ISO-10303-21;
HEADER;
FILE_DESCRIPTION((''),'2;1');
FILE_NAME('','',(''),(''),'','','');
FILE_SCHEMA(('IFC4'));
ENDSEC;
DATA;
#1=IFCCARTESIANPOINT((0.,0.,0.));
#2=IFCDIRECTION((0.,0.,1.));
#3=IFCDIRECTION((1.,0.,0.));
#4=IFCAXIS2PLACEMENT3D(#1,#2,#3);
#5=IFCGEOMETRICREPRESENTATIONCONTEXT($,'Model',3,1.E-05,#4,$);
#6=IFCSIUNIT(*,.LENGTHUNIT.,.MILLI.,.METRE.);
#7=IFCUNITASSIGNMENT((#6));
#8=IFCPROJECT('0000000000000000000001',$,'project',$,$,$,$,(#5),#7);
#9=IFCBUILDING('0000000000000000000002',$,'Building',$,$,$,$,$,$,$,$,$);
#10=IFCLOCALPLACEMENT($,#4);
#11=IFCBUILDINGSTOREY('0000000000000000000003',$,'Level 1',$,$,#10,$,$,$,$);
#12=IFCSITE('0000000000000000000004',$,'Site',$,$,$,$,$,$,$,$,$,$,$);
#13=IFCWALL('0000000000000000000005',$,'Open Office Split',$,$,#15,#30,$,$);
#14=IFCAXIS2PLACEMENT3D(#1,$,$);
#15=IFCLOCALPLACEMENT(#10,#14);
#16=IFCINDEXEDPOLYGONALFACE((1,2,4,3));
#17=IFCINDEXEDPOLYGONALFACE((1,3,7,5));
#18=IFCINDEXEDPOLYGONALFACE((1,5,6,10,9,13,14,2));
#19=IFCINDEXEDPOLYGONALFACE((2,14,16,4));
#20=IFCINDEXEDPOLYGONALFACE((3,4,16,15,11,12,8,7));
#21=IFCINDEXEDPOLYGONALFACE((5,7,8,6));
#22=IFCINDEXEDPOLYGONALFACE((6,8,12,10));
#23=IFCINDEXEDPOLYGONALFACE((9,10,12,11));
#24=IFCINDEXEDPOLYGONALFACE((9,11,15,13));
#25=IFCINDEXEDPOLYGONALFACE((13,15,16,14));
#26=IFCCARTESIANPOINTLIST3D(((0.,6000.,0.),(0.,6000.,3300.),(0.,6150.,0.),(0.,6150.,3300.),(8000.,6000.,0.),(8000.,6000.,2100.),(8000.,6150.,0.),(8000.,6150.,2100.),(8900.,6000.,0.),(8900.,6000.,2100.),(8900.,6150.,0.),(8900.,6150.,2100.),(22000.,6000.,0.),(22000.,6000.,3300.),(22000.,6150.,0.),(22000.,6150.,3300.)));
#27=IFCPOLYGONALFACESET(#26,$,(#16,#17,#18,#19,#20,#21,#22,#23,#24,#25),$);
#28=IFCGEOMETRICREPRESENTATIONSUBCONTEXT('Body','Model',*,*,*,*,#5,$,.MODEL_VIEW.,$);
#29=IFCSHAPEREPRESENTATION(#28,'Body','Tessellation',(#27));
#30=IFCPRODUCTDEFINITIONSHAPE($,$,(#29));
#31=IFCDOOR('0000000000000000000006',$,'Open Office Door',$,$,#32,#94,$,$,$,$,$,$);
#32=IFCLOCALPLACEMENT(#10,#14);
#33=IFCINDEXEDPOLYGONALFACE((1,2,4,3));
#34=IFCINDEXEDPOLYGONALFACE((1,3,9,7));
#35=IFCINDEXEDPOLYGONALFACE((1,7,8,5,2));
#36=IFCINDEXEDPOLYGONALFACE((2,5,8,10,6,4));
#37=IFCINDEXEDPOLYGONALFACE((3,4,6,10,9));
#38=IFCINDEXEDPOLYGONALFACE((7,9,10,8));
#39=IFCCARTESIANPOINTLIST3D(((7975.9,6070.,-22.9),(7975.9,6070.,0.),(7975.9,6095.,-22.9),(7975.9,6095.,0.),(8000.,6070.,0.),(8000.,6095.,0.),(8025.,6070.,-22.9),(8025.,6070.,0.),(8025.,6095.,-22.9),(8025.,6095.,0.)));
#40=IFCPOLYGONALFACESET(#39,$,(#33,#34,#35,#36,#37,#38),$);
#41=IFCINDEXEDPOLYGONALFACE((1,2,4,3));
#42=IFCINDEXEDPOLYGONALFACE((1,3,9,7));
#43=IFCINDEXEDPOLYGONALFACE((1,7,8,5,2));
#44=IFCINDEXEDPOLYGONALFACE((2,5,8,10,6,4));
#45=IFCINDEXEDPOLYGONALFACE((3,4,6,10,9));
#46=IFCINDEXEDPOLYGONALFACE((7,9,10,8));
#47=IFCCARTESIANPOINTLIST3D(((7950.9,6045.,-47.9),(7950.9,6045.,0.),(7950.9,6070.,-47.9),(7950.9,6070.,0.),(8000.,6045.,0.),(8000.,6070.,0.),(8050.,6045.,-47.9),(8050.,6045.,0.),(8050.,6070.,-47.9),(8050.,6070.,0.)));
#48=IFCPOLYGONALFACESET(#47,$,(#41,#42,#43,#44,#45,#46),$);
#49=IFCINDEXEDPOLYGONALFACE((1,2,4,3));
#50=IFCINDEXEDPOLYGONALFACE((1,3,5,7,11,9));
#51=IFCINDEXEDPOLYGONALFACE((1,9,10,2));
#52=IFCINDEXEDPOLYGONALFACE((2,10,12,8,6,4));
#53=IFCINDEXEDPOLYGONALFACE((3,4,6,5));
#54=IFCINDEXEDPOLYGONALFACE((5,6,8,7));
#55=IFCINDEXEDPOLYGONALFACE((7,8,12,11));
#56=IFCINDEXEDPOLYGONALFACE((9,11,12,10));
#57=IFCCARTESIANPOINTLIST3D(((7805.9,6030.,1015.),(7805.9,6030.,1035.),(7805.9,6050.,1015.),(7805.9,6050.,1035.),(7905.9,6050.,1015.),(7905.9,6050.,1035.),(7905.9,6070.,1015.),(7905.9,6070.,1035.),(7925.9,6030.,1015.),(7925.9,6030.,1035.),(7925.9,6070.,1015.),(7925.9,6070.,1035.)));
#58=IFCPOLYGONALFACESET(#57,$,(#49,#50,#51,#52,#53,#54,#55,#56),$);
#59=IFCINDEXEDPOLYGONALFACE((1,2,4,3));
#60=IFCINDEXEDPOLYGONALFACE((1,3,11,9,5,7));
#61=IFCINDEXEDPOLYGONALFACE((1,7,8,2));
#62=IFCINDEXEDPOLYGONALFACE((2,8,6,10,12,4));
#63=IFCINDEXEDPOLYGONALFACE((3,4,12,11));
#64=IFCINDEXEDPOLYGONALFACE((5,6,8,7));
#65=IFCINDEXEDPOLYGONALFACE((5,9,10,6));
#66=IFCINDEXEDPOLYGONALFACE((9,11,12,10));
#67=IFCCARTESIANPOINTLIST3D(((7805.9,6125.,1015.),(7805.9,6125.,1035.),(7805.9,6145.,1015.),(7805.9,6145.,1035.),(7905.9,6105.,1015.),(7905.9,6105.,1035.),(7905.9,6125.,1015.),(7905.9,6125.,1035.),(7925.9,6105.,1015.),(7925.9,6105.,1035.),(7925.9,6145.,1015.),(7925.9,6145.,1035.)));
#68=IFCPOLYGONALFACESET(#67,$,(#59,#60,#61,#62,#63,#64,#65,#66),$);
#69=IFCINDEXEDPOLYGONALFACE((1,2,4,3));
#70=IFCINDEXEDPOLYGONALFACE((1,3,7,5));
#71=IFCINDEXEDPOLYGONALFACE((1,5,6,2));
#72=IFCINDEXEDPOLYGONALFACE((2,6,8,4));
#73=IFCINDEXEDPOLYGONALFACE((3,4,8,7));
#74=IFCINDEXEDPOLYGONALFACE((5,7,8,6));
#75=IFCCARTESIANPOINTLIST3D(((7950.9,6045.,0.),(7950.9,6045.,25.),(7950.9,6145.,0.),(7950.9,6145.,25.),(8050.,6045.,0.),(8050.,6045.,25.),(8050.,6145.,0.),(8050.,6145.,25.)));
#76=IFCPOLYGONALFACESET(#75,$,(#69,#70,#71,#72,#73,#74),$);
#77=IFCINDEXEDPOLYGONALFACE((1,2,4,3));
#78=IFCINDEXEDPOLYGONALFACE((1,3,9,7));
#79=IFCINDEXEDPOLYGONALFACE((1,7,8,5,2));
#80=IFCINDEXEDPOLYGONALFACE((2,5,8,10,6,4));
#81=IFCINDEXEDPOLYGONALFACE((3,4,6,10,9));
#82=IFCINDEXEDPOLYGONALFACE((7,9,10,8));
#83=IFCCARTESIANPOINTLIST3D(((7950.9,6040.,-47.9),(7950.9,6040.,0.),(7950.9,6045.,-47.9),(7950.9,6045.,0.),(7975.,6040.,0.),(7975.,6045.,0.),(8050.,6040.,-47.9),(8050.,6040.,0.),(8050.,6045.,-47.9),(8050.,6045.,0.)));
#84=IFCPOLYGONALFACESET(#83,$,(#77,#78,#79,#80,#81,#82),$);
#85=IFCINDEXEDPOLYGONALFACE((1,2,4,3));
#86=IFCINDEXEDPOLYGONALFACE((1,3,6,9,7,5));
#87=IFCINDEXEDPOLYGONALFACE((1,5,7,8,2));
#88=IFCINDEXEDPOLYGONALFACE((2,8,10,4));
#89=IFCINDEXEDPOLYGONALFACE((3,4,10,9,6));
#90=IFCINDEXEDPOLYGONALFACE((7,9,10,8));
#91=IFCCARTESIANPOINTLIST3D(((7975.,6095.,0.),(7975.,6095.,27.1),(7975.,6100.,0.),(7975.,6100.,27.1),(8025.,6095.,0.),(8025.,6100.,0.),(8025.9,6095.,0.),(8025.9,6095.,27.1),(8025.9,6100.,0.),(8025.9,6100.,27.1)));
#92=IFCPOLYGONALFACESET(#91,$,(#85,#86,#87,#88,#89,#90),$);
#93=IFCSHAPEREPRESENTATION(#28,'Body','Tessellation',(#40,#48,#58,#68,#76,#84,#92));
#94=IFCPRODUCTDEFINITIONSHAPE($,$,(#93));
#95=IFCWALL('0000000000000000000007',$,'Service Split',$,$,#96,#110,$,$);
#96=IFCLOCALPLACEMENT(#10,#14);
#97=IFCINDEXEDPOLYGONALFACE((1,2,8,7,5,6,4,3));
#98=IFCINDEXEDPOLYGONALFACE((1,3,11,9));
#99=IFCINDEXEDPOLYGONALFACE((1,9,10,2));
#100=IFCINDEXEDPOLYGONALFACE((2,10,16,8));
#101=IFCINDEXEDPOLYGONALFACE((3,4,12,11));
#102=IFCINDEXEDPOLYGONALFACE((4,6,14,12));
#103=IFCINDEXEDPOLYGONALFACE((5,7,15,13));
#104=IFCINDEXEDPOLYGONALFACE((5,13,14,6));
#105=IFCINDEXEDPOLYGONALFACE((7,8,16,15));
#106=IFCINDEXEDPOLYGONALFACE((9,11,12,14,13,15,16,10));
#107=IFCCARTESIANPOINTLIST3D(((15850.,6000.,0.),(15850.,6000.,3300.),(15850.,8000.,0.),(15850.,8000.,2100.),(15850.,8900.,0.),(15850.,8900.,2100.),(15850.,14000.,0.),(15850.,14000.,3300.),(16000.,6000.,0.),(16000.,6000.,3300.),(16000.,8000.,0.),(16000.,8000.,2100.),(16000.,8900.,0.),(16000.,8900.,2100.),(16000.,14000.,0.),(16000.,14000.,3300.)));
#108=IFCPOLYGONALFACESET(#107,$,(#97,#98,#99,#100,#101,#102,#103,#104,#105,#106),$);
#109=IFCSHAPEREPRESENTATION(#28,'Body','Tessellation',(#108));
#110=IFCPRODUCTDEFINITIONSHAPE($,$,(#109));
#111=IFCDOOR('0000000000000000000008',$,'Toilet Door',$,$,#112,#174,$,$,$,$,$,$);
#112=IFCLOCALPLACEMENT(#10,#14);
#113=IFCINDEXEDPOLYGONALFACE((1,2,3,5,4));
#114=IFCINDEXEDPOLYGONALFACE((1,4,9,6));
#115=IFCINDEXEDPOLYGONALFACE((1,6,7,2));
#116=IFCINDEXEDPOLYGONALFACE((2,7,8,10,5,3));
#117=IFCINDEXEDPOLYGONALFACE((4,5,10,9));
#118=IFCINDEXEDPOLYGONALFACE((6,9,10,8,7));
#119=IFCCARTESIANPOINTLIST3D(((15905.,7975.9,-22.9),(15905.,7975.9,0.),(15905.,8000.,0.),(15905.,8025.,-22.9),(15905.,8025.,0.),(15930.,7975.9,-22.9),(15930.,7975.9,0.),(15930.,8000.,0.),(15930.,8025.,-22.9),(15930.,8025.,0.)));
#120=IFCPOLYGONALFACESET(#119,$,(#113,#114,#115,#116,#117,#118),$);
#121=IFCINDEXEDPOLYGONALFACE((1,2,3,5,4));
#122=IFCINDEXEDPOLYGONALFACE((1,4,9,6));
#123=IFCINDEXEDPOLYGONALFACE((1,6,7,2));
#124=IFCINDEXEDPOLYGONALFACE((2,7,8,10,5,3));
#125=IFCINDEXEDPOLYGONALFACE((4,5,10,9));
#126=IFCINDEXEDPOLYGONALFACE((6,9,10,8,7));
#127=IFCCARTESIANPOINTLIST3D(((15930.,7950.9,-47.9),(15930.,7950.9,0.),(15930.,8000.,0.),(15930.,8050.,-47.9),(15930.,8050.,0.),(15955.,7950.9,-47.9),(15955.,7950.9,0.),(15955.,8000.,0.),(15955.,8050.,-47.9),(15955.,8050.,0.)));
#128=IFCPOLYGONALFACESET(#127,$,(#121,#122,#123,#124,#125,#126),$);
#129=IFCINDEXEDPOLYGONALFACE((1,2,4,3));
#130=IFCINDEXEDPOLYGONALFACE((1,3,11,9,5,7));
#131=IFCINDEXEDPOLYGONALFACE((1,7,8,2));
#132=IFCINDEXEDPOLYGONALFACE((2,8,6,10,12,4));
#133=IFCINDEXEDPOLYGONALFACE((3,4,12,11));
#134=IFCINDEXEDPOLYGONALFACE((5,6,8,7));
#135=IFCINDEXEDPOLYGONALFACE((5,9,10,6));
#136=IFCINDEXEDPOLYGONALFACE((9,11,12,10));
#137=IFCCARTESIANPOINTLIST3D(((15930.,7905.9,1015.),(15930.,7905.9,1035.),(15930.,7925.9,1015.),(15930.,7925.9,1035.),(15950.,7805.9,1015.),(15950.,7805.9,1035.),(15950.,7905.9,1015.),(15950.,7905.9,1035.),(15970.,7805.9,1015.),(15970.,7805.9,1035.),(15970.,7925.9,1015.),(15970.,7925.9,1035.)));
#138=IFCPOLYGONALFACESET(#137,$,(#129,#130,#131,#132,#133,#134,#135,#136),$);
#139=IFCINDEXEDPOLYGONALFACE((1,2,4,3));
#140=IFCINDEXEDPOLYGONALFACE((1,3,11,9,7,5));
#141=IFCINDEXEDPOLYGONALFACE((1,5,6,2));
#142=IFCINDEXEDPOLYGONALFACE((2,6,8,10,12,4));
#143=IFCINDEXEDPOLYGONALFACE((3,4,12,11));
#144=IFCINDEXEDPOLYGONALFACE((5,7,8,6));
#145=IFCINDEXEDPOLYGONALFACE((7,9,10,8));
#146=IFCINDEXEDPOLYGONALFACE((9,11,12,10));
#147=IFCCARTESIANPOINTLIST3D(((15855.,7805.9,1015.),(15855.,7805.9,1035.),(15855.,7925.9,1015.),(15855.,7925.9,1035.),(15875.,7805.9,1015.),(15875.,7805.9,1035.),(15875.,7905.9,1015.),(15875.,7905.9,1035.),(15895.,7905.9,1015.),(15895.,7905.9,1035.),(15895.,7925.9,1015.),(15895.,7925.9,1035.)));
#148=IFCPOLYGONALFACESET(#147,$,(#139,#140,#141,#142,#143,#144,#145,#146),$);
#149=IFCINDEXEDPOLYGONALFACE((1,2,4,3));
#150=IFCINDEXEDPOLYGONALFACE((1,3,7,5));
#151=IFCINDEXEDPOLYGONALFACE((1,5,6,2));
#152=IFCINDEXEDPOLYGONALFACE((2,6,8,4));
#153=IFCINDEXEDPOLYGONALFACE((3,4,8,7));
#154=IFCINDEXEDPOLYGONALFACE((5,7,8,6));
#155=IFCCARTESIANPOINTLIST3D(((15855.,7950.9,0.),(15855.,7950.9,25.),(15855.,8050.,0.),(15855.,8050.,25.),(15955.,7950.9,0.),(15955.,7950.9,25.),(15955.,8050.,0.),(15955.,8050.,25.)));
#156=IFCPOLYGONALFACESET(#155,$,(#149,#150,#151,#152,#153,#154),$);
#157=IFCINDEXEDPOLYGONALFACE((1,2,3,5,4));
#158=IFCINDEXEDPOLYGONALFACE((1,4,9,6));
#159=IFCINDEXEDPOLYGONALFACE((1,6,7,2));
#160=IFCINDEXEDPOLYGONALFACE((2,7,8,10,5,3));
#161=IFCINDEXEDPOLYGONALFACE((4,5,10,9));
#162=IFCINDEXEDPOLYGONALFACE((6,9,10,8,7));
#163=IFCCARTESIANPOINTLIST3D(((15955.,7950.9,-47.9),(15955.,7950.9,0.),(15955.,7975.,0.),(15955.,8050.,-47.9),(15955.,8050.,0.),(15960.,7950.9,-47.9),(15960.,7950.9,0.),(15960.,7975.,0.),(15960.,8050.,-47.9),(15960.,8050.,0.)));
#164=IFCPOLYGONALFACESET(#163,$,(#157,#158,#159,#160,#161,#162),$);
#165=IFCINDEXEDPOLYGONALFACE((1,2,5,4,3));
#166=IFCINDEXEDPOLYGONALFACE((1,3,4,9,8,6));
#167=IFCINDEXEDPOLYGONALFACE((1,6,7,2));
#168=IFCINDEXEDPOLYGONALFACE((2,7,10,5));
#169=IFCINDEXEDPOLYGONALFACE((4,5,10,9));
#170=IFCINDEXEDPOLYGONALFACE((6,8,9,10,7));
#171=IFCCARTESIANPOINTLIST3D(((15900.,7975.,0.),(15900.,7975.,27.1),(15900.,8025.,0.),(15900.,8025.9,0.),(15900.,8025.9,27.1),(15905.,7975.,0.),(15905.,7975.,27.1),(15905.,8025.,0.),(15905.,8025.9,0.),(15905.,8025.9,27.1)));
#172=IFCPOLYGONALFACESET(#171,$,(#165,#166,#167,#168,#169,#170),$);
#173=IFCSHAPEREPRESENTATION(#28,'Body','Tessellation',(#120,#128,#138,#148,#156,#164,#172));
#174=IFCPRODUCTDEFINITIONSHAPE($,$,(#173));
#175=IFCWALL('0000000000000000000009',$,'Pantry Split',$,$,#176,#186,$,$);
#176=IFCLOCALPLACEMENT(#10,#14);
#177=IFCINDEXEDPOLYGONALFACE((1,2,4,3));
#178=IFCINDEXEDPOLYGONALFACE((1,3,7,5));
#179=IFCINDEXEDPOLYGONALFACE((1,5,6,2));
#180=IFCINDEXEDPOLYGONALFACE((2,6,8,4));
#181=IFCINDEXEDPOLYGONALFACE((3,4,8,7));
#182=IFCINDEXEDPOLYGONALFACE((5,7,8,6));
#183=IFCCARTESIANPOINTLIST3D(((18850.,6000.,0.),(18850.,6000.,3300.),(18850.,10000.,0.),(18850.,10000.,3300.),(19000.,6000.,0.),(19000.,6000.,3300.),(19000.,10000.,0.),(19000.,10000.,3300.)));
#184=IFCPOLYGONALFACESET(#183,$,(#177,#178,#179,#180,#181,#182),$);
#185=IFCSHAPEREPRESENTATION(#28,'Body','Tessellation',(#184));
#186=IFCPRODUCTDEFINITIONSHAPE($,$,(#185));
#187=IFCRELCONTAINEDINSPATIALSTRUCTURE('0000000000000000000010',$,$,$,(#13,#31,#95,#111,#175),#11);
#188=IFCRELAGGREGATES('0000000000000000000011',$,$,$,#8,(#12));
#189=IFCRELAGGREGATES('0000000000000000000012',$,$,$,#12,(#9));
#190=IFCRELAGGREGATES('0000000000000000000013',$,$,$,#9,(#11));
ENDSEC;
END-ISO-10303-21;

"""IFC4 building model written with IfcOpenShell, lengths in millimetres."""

from ifc_helpers import new_model, si_unit, frame, origin_with_axes, place, context, subcontext, project, spatial, line, indexed_curve, outline, extrude, element, fill, save


model = new_model("IFC4")

# Units and contexts
model_context = context("Model", 3, precision=1e-05, world=origin_with_axes())
body_context = subcontext(model_context, "Body", "Model", "MODEL_VIEW")
ifc_project = project(units=[si_unit("LENGTHUNIT", "METRE", prefix="MILLI")], contexts=[model_context])

# Site, building, storey
site = spatial("IfcSite", under=ifc_project, Name="Site")
building = spatial("IfcBuilding", under=site, Name="Building")
storey_placement = place(None, origin_with_axes())
storey = spatial("IfcBuildingStorey", under=building, at=storey_placement, Name="Level 1")

# Walls, openings, doors
wall_1_placement = place(storey_placement, frame((0.0, 6000.0, 0.0), z_axis=(0.0, 0.0, 1.0), x_axis=(1.0, 0.0, 0.0)))
wall_1 = element("IfcWall", 1, at=wall_1_placement, inside=storey, Name="Open Office Split", context=body_context, shape_type="SweptSolid", body=[
    extrude(outline(indexed_curve([(0.0, 0.0), (0.0, 150.0), (22000.0, 150.0), (22000.0, 0.0), (0.0, 0.0)], self_intersect=False)), origin_with_axes(), (0.0, 0.0, 1.0), 3300.0),
])
opening_1_placement = place(wall_1_placement, frame((8000.0, -100.0, 0.0), z_axis=(0.0, 0.0, 1.0), x_axis=(1.0, 0.0, 0.0)))
opening_1 = element("IfcOpeningElement", 2, at=opening_1_placement, cuts=wall_1, context=body_context, shape_type="SweptSolid", body=[
    extrude(outline(indexed_curve([(0.0, 0.0), (0.0, 350.0), (900.0, 350.0), (900.0, 0.0), (0.0, 0.0)], self_intersect=False)), origin_with_axes(), (0.0, 0.0, 1.0), 2100.0),
])
door_1_placement = place(opening_1_placement, frame((0.0, 145.0, 0.0), z_axis=(0.0, 0.0, 1.0), x_axis=(1.0, 0.0, 0.0)))
door_1 = element("IfcDoor", 3, at=door_1_placement, inside=storey, Name="Open Office Door", context=body_context, shape_type="SweptSolid", body=[
    extrude(outline(indexed_curve([(0.0, 0.0), (0.0, 2.1), (0.9, 2.1), (0.9, 0.0), (-24.1, 0.0), (-24.1, -22.9), (25.0, -22.9), (25.0, 0.0)], segments=[line(1, 2, 3, 4, 5, 6, 7, 8, 1)])), frame((0.0, 25.0, 0.0), z_axis=(0.0, -1.0, 0.0), x_axis=(1.0, 0.0, 0.0)), (0.0, 0.0, -1.0), 25.0),
    extrude(outline(indexed_curve([(0.0, 0.0), (0.0, 2.1), (0.9, 2.1), (0.9, 0.0), (-49.1, 0.0), (-49.1, -47.9), (50.0, -47.9), (50.0, 0.0)], segments=[line(1, 2, 3, 4, 5, 6, 7, 8, 1)])), frame((0.0, 0.0, 0.0), z_axis=(0.0, -1.0, 0.0), x_axis=(1.0, 0.0, 0.0)), (0.0, 0.0, -1.0), 25.0),
    extrude(outline(indexed_curve([(0.0, 0.0), (-49.1, 0.0), (-49.1, 35.0), (0.0, 35.0)], segments=[line(1, 2, 3, 4, 1)])), frame((25.0, 25.0, 25.0), z_axis=(0.0, 0.0, 1.0), x_axis=(1.0, 0.0, 0.0)), (0.0, 0.0, 1.0), -47.9),
    extrude(outline(indexed_curve([(0.0, 0.0), (0.0, -40.0), (-120.0, -40.0), (-120.0, -20.0), (-20.0, -20.0), (-20.0, 0.0)], segments=[line(1, 2, 3, 4, 5, 6, 1)])), frame((-74.1, 25.0, 1015.0), z_axis=(0.0, 0.0, 1.0), x_axis=(1.0, 0.0, 0.0)), (0.0, 0.0, 1.0), 20.0),
    extrude(outline(indexed_curve([(0.0, 0.0), (0.0, 40.0), (-120.0, 40.0), (-120.0, 20.0), (-20.0, 20.0), (-20.0, 0.0)], segments=[line(1, 2, 3, 4, 5, 6, 1)])), frame((-74.1, 60.0, 1015.0), z_axis=(0.0, 0.0, 1.0), x_axis=(1.0, 0.0, 0.0)), (0.0, 0.0, 1.0), 20.0),
    extrude(outline(indexed_curve([(0.0, 0.0), (-99.1, 0.0), (-99.1, 100.0), (0.0, 100.0)], segments=[line(1, 2, 3, 4, 1)])), frame((50.0, 0.0, 0.0), z_axis=(0.0, 0.0, 1.0), x_axis=(1.0, 0.0, 0.0)), (0.0, 0.0, 1.0), 25.0),
    extrude(outline(indexed_curve([(0.0, 0.0), (0.0, 27.1), (50.9, 27.1), (50.9, 0.0), (-24.1, 0.0), (-24.1, -47.9), (75.0, -47.9), (75.0, 0.0)], segments=[line(1, 2, 3, 4, 5, 6, 7, 8, 1)])), frame((-25.0, -5.0, 0.0), z_axis=(0.0, -1.0, 0.0), x_axis=(1.0, 0.0, 0.0)), (0.0, 0.0, -1.0), 5.0),
    extrude(outline(indexed_curve([(0.0, 0.0), (0.0, 27.1), (50.9, 27.1), (50.9, 0.0), (0.9, 0.0), (0.9, -22.9), (50.0, -22.9), (50.0, 0.0)], segments=[line(1, 2, 3, 4, 5, 6, 7, 8, 1)])), frame((-25.0, 50.0, 0.0), z_axis=(0.0, -1.0, 0.0), x_axis=(1.0, 0.0, 0.0)), (0.0, 0.0, -1.0), 5.0),
])
fill(opening_1, door_1)
wall_2_placement = place(storey_placement, frame((16000.0, 6000.0, 0.0), z_axis=(0.0, 0.0, 1.0), x_axis=(0.0, 1.0, 0.0)))
wall_2 = element("IfcWall", 4, at=wall_2_placement, inside=storey, Name="Service Split", context=body_context, shape_type="SweptSolid", body=[
    extrude(outline(indexed_curve([(0.0, 0.0), (0.0, 150.0), (8000.0, 150.0), (8000.0, 0.0), (0.0, 0.0)], self_intersect=False)), origin_with_axes(), (0.0, 0.0, 1.0), 3300.0),
])
opening_2_placement = place(wall_2_placement, frame((2000.0, -100.0, 0.0), z_axis=(0.0, 0.0, 1.0), x_axis=(1.0, 0.0, 0.0)))
opening_2 = element("IfcOpeningElement", 5, at=opening_2_placement, cuts=wall_2, context=body_context, shape_type="SweptSolid", body=[
    extrude(outline(indexed_curve([(0.0, 0.0), (0.0, 350.0), (900.0, 350.0), (900.0, 0.0), (0.0, 0.0)], self_intersect=False)), origin_with_axes(), (0.0, 0.0, 1.0), 2100.0),
])
door_2_placement = place(opening_2_placement, frame((0.0, 145.0, 0.0), z_axis=(0.0, 0.0, 1.0), x_axis=(1.0, 0.0, 0.0)))
door_2 = element("IfcDoor", 6, at=door_2_placement, inside=storey, Name="Toilet Door", context=body_context, shape_type="SweptSolid", body=[
    extrude(outline(indexed_curve([(0.0, 0.0), (0.0, 2.1), (0.9, 2.1), (0.9, 0.0), (-24.1, 0.0), (-24.1, -22.9), (25.0, -22.9), (25.0, 0.0)], segments=[line(1, 2, 3, 4, 5, 6, 7, 8, 1)])), frame((0.0, 25.0, 0.0), z_axis=(0.0, -1.0, 0.0), x_axis=(1.0, 0.0, 0.0)), (0.0, 0.0, -1.0), 25.0),
    extrude(outline(indexed_curve([(0.0, 0.0), (0.0, 2.1), (0.9, 2.1), (0.9, 0.0), (-49.1, 0.0), (-49.1, -47.9), (50.0, -47.9), (50.0, 0.0)], segments=[line(1, 2, 3, 4, 5, 6, 7, 8, 1)])), frame((0.0, 0.0, 0.0), z_axis=(0.0, -1.0, 0.0), x_axis=(1.0, 0.0, 0.0)), (0.0, 0.0, -1.0), 25.0),
    extrude(outline(indexed_curve([(0.0, 0.0), (-49.1, 0.0), (-49.1, 35.0), (0.0, 35.0)], segments=[line(1, 2, 3, 4, 1)])), frame((25.0, 25.0, 25.0), z_axis=(0.0, 0.0, 1.0), x_axis=(1.0, 0.0, 0.0)), (0.0, 0.0, 1.0), -47.9),
    extrude(outline(indexed_curve([(0.0, 0.0), (0.0, -40.0), (-120.0, -40.0), (-120.0, -20.0), (-20.0, -20.0), (-20.0, 0.0)], segments=[line(1, 2, 3, 4, 5, 6, 1)])), frame((-74.1, 25.0, 1015.0), z_axis=(0.0, 0.0, 1.0), x_axis=(1.0, 0.0, 0.0)), (0.0, 0.0, 1.0), 20.0),
    extrude(outline(indexed_curve([(0.0, 0.0), (0.0, 40.0), (-120.0, 40.0), (-120.0, 20.0), (-20.0, 20.0), (-20.0, 0.0)], segments=[line(1, 2, 3, 4, 5, 6, 1)])), frame((-74.1, 60.0, 1015.0), z_axis=(0.0, 0.0, 1.0), x_axis=(1.0, 0.0, 0.0)), (0.0, 0.0, 1.0), 20.0),
    extrude(outline(indexed_curve([(0.0, 0.0), (-99.1, 0.0), (-99.1, 100.0), (0.0, 100.0)], segments=[line(1, 2, 3, 4, 1)])), frame((50.0, 0.0, 0.0), z_axis=(0.0, 0.0, 1.0), x_axis=(1.0, 0.0, 0.0)), (0.0, 0.0, 1.0), 25.0),
    extrude(outline(indexed_curve([(0.0, 0.0), (0.0, 27.1), (50.9, 27.1), (50.9, 0.0), (-24.1, 0.0), (-24.1, -47.9), (75.0, -47.9), (75.0, 0.0)], segments=[line(1, 2, 3, 4, 5, 6, 7, 8, 1)])), frame((-25.0, -5.0, 0.0), z_axis=(0.0, -1.0, 0.0), x_axis=(1.0, 0.0, 0.0)), (0.0, 0.0, -1.0), 5.0),
    extrude(outline(indexed_curve([(0.0, 0.0), (0.0, 27.1), (50.9, 27.1), (50.9, 0.0), (0.9, 0.0), (0.9, -22.9), (50.0, -22.9), (50.0, 0.0)], segments=[line(1, 2, 3, 4, 5, 6, 7, 8, 1)])), frame((-25.0, 50.0, 0.0), z_axis=(0.0, -1.0, 0.0), x_axis=(1.0, 0.0, 0.0)), (0.0, 0.0, -1.0), 5.0),
])
fill(opening_2, door_2)

# Wall
wall_3_placement = place(storey_placement, frame((19000.0, 6000.0, 0.0), z_axis=(0.0, 0.0, 1.0), x_axis=(0.0, 1.0, 0.0)))
element("IfcWall", 7, at=wall_3_placement, inside=storey, Name="Pantry Split", context=body_context, shape_type="SweptSolid", body=[
    extrude(outline(indexed_curve([(0.0, 0.0), (0.0, 150.0), (4000.0, 150.0), (4000.0, 0.0), (0.0, 0.0)], self_intersect=False)), origin_with_axes(), (0.0, 0.0, 1.0), 3300.0),
])

save(model, "model.ifc")
